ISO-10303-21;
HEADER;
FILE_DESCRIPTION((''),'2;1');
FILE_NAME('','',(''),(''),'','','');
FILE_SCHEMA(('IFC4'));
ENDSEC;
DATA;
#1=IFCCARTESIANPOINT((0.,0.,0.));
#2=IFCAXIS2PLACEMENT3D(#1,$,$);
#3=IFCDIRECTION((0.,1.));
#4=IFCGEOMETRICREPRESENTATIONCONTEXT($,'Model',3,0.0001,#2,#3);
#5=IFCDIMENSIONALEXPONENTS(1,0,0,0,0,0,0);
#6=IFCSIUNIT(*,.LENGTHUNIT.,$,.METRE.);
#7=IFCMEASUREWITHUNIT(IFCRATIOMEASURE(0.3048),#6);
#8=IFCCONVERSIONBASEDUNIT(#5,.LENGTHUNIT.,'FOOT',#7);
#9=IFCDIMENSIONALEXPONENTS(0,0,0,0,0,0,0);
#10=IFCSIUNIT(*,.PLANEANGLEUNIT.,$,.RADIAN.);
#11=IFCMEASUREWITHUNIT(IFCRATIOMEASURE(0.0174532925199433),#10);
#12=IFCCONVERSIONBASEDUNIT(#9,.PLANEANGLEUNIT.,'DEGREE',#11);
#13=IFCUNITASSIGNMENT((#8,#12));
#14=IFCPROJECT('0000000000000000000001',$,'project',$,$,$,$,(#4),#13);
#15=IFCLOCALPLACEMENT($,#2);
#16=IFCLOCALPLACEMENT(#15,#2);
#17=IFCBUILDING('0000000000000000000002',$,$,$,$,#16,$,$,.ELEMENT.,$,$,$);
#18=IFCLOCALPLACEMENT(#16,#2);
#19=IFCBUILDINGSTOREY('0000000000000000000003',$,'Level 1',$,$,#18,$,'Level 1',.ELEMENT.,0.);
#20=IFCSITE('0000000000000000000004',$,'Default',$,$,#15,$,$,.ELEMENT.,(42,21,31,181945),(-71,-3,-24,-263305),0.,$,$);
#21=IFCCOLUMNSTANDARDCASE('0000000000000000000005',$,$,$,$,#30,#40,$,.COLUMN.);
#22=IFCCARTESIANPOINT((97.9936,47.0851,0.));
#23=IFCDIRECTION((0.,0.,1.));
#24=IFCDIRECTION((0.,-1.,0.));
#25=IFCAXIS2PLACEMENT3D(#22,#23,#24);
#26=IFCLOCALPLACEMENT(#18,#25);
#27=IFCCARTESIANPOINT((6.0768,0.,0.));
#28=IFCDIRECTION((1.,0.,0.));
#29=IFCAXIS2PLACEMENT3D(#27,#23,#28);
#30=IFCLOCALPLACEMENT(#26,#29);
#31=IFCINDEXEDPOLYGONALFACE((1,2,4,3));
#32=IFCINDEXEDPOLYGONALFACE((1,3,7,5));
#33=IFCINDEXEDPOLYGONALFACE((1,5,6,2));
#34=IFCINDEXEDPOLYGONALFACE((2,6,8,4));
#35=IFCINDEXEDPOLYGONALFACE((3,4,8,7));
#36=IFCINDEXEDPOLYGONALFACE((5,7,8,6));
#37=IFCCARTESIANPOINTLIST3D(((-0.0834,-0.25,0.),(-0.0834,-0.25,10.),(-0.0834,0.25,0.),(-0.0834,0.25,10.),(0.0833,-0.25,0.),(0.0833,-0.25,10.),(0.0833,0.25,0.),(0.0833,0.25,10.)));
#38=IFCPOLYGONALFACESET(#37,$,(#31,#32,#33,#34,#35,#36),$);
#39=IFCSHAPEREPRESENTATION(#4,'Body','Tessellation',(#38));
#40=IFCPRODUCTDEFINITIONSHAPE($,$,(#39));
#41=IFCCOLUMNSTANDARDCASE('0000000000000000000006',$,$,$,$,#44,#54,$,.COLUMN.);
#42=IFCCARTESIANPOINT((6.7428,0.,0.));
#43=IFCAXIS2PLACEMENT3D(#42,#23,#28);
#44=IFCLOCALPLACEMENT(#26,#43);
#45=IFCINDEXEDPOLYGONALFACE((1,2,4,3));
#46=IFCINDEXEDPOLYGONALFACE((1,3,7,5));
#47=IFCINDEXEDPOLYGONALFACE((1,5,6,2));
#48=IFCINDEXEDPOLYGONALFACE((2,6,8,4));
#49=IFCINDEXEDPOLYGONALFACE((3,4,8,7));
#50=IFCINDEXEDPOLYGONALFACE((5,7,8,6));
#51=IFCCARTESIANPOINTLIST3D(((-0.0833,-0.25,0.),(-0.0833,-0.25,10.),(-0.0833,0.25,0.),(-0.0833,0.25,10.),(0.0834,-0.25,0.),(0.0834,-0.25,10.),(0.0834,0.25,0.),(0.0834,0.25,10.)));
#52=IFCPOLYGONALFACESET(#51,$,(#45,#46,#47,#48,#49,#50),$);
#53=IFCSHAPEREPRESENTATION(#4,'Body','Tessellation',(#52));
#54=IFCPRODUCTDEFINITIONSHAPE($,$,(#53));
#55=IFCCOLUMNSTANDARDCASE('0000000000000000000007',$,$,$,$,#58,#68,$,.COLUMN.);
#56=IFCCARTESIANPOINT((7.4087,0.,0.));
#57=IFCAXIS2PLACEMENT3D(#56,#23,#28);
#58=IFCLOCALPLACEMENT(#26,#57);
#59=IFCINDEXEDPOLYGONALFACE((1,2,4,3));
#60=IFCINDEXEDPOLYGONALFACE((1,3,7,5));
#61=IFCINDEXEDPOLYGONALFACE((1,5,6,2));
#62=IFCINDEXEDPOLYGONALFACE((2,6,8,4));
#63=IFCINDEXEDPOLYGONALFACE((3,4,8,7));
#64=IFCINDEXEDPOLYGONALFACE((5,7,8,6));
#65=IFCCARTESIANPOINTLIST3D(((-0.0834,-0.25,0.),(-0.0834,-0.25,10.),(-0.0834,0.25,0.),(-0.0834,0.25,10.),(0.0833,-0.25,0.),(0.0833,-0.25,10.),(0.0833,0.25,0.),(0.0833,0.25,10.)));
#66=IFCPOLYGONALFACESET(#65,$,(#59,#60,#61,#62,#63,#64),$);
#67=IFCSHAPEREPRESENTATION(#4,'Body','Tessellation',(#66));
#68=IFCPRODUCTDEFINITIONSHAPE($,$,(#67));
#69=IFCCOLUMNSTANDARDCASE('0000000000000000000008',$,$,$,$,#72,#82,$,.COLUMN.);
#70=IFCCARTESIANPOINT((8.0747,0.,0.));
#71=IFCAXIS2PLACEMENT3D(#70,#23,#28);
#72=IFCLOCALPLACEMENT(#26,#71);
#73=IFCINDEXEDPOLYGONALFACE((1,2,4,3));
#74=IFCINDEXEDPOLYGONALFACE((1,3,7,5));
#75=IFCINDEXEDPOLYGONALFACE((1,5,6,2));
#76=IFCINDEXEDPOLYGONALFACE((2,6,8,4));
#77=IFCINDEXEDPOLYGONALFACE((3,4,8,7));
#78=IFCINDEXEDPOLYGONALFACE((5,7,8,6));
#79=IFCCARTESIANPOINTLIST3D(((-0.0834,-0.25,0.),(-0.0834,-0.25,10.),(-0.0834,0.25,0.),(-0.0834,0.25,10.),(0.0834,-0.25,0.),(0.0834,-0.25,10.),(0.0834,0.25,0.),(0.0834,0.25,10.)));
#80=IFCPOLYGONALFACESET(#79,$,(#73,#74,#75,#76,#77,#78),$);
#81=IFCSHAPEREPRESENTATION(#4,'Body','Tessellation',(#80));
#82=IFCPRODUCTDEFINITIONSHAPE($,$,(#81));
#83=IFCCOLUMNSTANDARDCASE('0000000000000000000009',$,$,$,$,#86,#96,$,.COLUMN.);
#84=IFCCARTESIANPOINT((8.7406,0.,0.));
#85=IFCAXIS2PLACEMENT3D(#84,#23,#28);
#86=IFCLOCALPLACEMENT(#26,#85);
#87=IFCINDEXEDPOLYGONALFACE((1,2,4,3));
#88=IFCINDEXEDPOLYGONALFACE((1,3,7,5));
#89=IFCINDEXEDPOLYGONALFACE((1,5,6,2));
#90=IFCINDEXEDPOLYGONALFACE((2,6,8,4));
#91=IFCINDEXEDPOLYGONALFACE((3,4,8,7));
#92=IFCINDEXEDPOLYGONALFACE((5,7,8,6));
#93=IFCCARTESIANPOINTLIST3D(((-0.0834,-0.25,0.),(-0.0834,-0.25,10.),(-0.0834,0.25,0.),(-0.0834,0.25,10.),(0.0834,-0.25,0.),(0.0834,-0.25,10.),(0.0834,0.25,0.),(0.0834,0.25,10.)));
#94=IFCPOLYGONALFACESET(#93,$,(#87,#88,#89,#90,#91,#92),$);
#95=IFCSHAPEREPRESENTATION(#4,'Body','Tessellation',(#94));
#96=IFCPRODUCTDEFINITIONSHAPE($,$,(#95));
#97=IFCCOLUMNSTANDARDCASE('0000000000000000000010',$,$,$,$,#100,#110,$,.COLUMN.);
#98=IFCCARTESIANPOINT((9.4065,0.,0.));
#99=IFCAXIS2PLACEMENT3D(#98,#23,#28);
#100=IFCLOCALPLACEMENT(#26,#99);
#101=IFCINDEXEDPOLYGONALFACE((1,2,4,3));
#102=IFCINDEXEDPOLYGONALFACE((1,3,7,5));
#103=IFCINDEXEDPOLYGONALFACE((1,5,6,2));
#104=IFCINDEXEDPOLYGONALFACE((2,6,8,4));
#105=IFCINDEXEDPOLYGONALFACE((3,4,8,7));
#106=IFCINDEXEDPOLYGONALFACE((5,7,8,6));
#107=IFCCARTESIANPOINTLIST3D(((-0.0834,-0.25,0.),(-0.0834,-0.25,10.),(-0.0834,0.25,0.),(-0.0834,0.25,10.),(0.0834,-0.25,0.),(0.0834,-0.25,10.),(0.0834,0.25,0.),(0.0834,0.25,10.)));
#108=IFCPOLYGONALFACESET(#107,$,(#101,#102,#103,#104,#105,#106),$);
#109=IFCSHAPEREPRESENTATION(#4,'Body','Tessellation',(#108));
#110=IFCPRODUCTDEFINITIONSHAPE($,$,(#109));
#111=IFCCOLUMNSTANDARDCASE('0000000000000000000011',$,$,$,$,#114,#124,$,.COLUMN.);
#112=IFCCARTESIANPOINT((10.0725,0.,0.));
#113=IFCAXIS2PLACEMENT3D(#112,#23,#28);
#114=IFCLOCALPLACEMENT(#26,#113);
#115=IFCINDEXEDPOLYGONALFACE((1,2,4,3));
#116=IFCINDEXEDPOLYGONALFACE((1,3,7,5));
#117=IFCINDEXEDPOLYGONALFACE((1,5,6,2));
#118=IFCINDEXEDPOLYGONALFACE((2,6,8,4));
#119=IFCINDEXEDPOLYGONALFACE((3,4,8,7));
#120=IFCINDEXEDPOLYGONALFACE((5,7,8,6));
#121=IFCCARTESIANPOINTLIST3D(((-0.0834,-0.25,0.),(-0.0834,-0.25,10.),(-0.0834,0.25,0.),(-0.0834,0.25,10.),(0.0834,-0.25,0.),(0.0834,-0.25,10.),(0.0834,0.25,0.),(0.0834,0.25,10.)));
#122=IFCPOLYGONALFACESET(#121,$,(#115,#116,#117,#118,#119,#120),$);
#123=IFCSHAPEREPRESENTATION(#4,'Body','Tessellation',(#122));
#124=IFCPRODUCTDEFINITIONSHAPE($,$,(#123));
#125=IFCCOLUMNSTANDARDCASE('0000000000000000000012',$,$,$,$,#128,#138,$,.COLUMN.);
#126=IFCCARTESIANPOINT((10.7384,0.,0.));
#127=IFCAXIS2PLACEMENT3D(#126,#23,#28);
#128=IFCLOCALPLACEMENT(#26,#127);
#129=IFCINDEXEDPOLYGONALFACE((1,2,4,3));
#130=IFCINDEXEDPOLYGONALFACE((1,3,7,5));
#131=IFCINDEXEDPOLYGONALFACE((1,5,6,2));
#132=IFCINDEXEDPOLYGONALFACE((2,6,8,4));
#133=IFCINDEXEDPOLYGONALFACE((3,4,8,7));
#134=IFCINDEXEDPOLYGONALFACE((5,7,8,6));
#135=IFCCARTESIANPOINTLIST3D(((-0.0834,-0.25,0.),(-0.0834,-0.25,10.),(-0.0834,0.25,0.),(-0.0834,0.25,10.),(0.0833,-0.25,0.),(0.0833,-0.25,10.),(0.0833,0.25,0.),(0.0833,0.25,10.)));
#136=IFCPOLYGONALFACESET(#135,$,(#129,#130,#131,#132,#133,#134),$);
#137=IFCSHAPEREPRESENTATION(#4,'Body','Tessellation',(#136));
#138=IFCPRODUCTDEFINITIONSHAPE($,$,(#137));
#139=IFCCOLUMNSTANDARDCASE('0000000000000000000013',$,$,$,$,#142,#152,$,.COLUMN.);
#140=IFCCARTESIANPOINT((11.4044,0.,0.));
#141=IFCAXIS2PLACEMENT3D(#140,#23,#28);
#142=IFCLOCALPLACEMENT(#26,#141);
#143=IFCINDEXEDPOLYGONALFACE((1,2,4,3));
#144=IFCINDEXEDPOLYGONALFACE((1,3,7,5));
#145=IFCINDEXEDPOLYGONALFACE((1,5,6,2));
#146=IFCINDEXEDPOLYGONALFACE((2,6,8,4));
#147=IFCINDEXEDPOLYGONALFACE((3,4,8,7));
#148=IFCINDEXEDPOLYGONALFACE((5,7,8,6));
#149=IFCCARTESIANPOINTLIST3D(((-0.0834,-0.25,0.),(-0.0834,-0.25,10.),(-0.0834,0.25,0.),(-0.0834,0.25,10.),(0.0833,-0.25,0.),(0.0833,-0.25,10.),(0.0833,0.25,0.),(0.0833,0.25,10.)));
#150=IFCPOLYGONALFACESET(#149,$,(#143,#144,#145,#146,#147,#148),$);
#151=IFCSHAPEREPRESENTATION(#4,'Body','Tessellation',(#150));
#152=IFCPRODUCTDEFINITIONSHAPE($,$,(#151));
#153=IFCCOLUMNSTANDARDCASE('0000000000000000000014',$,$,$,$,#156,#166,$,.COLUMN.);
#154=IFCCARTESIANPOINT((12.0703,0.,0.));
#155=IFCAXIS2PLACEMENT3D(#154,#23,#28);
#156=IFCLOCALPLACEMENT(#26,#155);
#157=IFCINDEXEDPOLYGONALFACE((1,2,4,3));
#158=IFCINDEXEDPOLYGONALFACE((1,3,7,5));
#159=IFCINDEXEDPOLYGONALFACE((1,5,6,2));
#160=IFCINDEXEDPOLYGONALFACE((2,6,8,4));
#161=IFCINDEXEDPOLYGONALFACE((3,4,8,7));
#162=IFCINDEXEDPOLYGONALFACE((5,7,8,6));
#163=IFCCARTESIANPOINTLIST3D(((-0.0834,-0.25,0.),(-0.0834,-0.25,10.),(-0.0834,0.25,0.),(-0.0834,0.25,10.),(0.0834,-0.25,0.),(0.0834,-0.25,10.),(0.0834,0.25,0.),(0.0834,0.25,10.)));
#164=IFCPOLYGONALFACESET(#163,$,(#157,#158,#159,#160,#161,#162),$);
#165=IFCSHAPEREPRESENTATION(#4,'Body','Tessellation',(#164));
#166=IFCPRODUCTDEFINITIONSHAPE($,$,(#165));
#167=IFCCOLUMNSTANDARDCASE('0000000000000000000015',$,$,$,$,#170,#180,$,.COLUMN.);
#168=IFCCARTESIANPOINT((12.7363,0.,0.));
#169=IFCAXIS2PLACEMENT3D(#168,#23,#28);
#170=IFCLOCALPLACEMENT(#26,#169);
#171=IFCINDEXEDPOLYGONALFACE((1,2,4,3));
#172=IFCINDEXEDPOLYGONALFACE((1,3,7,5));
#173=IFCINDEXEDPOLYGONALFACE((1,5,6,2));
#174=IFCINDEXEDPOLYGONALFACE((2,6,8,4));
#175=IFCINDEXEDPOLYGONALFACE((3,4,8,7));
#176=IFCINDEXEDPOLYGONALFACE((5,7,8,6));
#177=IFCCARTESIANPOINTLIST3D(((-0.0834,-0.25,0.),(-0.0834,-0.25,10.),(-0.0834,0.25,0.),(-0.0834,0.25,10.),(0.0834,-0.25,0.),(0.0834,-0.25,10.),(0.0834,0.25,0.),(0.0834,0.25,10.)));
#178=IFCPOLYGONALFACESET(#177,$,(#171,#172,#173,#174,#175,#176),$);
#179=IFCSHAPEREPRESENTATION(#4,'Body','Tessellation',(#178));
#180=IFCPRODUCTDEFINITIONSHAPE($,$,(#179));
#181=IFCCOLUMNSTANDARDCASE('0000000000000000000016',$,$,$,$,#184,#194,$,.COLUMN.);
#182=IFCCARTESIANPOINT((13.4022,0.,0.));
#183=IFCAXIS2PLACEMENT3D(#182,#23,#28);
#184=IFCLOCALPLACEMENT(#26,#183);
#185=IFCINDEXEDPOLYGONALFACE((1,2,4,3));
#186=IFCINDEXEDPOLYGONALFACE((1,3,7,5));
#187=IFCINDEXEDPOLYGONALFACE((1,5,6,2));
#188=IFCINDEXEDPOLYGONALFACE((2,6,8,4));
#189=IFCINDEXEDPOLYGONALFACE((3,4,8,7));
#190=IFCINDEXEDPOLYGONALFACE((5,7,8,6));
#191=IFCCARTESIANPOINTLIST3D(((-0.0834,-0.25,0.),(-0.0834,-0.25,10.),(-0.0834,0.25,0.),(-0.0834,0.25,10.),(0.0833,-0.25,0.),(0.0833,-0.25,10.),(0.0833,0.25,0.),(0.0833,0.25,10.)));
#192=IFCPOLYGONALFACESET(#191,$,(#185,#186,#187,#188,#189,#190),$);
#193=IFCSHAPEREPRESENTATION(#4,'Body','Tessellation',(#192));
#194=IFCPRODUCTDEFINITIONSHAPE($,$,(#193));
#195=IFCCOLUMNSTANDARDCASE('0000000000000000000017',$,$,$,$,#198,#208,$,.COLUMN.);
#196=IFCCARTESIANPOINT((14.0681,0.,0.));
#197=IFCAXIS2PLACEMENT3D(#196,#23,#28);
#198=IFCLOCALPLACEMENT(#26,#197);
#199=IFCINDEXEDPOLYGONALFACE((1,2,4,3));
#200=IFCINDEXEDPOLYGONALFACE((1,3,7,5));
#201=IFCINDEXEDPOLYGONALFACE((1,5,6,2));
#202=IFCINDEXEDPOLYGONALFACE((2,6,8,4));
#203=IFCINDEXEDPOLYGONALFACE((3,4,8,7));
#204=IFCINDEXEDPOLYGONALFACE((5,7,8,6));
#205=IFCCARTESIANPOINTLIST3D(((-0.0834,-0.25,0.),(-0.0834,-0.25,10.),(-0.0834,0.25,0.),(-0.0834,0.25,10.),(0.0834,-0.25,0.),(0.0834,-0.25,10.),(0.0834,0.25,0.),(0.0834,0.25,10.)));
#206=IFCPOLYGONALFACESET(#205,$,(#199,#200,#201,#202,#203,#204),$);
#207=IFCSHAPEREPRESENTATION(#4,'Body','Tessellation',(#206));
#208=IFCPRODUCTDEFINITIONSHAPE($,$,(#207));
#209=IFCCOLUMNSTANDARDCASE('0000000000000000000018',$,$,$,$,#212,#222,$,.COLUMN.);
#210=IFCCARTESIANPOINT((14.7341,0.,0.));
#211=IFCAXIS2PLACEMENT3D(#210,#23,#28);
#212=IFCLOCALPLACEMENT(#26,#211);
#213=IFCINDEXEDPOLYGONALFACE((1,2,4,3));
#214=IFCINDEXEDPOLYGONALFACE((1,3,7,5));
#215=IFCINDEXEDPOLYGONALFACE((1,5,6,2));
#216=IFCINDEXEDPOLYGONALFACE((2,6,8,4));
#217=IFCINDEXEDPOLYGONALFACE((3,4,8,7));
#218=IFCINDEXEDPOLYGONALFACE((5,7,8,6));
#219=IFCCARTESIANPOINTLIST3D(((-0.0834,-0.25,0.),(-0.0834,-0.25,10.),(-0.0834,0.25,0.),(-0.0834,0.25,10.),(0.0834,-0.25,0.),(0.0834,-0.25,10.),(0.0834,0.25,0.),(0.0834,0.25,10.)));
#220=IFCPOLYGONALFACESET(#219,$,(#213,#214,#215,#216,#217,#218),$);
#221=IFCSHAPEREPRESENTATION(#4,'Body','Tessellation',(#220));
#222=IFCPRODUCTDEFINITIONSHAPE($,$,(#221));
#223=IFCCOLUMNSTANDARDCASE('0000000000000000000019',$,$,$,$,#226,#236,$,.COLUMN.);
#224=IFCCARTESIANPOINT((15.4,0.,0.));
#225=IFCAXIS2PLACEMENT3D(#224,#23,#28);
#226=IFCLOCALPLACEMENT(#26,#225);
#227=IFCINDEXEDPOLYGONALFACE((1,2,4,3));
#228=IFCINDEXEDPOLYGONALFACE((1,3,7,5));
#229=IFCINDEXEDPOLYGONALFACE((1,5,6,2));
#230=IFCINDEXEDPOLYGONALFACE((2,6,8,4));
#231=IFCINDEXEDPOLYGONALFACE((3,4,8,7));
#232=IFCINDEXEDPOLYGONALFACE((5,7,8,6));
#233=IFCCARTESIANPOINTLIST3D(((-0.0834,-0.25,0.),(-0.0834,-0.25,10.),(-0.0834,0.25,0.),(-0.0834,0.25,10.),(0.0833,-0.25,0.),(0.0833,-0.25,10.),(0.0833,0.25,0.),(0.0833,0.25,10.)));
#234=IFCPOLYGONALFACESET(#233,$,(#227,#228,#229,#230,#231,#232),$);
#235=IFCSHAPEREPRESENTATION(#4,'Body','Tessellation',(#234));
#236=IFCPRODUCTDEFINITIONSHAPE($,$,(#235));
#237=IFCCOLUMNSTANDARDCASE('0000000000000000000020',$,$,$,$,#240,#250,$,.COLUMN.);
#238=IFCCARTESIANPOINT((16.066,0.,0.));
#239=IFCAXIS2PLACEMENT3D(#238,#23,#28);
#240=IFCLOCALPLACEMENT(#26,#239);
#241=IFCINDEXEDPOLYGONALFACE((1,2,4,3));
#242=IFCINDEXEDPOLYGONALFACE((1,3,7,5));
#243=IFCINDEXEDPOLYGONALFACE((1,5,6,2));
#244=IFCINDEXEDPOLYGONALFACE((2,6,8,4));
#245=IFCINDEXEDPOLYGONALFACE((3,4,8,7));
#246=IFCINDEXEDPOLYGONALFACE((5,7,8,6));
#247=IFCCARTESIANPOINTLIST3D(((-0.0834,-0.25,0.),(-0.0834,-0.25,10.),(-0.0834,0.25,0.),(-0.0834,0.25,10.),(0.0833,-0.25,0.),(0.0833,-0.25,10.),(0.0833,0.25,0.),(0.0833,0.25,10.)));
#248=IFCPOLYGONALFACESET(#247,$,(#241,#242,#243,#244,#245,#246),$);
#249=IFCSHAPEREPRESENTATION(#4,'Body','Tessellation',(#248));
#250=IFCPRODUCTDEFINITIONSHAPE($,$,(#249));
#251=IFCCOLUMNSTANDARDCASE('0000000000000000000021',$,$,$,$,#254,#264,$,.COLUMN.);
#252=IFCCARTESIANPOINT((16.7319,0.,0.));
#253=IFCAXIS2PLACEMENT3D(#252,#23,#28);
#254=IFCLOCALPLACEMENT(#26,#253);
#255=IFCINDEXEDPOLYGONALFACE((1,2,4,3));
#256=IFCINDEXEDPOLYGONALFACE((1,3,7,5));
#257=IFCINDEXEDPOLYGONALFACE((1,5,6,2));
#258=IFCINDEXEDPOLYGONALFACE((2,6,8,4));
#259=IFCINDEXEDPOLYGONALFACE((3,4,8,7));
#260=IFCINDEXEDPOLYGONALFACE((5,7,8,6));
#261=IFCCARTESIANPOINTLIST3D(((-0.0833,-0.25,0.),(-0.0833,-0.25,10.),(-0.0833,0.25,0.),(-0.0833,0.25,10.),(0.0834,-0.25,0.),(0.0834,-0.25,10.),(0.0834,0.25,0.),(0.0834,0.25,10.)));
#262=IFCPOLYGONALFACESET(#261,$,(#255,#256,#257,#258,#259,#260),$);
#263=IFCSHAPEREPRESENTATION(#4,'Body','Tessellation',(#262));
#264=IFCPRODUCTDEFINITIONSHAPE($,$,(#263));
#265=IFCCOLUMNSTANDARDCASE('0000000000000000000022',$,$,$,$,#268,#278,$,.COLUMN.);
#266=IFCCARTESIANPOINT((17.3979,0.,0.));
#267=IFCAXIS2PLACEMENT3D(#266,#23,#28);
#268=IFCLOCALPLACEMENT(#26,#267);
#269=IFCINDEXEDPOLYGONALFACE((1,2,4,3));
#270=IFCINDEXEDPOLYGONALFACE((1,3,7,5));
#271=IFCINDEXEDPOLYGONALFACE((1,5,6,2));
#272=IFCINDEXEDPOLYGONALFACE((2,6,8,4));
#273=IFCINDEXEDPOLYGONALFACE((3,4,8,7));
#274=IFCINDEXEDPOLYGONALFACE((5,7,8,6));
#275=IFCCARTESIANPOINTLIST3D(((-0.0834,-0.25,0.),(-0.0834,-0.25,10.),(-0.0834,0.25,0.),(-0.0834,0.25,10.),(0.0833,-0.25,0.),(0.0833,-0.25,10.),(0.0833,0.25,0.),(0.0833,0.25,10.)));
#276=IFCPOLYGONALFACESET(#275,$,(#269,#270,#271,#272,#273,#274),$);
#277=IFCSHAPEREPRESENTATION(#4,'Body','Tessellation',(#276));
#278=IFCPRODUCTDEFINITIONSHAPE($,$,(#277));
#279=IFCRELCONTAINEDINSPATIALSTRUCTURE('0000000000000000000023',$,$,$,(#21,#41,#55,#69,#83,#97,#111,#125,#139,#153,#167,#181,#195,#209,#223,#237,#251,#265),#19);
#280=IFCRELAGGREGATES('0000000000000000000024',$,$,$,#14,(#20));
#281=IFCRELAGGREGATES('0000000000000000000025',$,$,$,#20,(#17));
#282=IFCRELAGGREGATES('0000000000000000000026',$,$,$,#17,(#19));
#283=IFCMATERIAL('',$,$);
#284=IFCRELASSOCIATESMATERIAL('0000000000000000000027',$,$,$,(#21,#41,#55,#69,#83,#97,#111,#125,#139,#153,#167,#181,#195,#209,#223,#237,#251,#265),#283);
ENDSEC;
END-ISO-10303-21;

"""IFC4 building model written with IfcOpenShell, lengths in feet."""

from ifc_helpers import new_model, entity, si_unit, converted_unit, direction, frame, origin, place, context, project, spatial, rectangle, extrude, material, element, save


model = new_model("IFC4")

# Units and contexts
model_context = context("Model", 3, precision=0.0001, world=origin(), true_north=direction((0.0, 1.0)))
ifc_project = project(units=[converted_unit("LENGTHUNIT", "FOOT", entity("IfcRatioMeasure", 0.3048), si_unit("LENGTHUNIT", "METRE"), dimensions=[1, 0, 0, 0, 0, 0, 0]), converted_unit("PLANEANGLEUNIT", "DEGREE", entity("IfcRatioMeasure", 0.0174532925199433), si_unit("PLANEANGLEUNIT", "RADIAN"), dimensions=[0, 0, 0, 0, 0, 0, 0])], contexts=[model_context])

# Site, building, storey
site_placement = place(None, origin())
site = spatial("IfcSite", under=ifc_project, at=site_placement, Name="Default", CompositionType="ELEMENT", RefLatitude=(42, 21, 31, 181945), RefLongitude=(-71, -3, -24, -263305), RefElevation=0.0)
building_placement = place(site_placement, origin())
building = spatial("IfcBuilding", under=site, at=building_placement, CompositionType="ELEMENT")
storey_placement = place(building_placement, origin())
storey = spatial("IfcBuildingStorey", under=building, at=storey_placement, Name="Level 1", LongName="Level 1", CompositionType="ELEMENT", Elevation=0.0)

# Columns
ifc_material = material(Name="")
placement = place(storey_placement, frame((97.9936, 47.0851, 0.0), z_axis=(0.0, 0.0, 1.0), x_axis=(0.0, -1.0, 0.0)))
for number, where, z_axis, x_axis in (
    (1, (6.0768, 0.0, 0.0), (0.0, 0.0, 1.0), (1.0, 0.0, 0.0)),
    (2, (6.7428, 0.0, 0.0), (0.0, 0.0, 1.0), (1.0, 0.0, 0.0)),
    (3, (7.4087, 0.0, 0.0), (0.0, 0.0, 1.0), (1.0, 0.0, 0.0)),
    (4, (8.0747, 0.0, 0.0), (0.0, 0.0, 1.0), (1.0, 0.0, 0.0)),
    (5, (8.7406, 0.0, 0.0), (0.0, 0.0, 1.0), (1.0, 0.0, 0.0)),
    (6, (9.4065, 0.0, 0.0), (0.0, 0.0, 1.0), (1.0, 0.0, 0.0)),
    (7, (10.0725, 0.0, 0.0), (0.0, 0.0, 1.0), (1.0, 0.0, 0.0)),
    (8, (10.7384, 0.0, 0.0), (0.0, 0.0, 1.0), (1.0, 0.0, 0.0)),
    (9, (11.4044, 0.0, 0.0), (0.0, 0.0, 1.0), (1.0, 0.0, 0.0)),
    (10, (12.0703, 0.0, 0.0), (0.0, 0.0, 1.0), (1.0, 0.0, 0.0)),
    (11, (12.7363, 0.0, 0.0), (0.0, 0.0, 1.0), (1.0, 0.0, 0.0)),
    (12, (13.4022, 0.0, 0.0), (0.0, 0.0, 1.0), (1.0, 0.0, 0.0)),
    (13, (14.0681, 0.0, 0.0), (0.0, 0.0, 1.0), (1.0, 0.0, 0.0)),
    (14, (14.7341, 0.0, 0.0), (0.0, 0.0, 1.0), (1.0, 0.0, 0.0)),
    (15, (15.4, 0.0, 0.0), (0.0, 0.0, 1.0), (1.0, 0.0, 0.0)),
    (16, (16.066, 0.0, 0.0), (0.0, 0.0, 1.0), (1.0, 0.0, 0.0)),
    (17, (16.7319, 0.0, 0.0), (0.0, 0.0, 1.0), (1.0, 0.0, 0.0)),
    (18, (17.3979, 0.0, 0.0), (0.0, 0.0, 1.0), (1.0, 0.0, 0.0)),
):
    element("IfcColumnStandardCase", number, at=place(placement, frame(where, z_axis=z_axis, x_axis=x_axis)), inside=storey, material=ifc_material, PredefinedType="COLUMN", context=model_context, shape_type="SweptSolid", body=[
        extrude(rectangle(XDim=0.1667, YDim=0.5), origin(), (0.0, 0.0, 1.0), 10.0),
    ])

save(model, "model.ifc")
